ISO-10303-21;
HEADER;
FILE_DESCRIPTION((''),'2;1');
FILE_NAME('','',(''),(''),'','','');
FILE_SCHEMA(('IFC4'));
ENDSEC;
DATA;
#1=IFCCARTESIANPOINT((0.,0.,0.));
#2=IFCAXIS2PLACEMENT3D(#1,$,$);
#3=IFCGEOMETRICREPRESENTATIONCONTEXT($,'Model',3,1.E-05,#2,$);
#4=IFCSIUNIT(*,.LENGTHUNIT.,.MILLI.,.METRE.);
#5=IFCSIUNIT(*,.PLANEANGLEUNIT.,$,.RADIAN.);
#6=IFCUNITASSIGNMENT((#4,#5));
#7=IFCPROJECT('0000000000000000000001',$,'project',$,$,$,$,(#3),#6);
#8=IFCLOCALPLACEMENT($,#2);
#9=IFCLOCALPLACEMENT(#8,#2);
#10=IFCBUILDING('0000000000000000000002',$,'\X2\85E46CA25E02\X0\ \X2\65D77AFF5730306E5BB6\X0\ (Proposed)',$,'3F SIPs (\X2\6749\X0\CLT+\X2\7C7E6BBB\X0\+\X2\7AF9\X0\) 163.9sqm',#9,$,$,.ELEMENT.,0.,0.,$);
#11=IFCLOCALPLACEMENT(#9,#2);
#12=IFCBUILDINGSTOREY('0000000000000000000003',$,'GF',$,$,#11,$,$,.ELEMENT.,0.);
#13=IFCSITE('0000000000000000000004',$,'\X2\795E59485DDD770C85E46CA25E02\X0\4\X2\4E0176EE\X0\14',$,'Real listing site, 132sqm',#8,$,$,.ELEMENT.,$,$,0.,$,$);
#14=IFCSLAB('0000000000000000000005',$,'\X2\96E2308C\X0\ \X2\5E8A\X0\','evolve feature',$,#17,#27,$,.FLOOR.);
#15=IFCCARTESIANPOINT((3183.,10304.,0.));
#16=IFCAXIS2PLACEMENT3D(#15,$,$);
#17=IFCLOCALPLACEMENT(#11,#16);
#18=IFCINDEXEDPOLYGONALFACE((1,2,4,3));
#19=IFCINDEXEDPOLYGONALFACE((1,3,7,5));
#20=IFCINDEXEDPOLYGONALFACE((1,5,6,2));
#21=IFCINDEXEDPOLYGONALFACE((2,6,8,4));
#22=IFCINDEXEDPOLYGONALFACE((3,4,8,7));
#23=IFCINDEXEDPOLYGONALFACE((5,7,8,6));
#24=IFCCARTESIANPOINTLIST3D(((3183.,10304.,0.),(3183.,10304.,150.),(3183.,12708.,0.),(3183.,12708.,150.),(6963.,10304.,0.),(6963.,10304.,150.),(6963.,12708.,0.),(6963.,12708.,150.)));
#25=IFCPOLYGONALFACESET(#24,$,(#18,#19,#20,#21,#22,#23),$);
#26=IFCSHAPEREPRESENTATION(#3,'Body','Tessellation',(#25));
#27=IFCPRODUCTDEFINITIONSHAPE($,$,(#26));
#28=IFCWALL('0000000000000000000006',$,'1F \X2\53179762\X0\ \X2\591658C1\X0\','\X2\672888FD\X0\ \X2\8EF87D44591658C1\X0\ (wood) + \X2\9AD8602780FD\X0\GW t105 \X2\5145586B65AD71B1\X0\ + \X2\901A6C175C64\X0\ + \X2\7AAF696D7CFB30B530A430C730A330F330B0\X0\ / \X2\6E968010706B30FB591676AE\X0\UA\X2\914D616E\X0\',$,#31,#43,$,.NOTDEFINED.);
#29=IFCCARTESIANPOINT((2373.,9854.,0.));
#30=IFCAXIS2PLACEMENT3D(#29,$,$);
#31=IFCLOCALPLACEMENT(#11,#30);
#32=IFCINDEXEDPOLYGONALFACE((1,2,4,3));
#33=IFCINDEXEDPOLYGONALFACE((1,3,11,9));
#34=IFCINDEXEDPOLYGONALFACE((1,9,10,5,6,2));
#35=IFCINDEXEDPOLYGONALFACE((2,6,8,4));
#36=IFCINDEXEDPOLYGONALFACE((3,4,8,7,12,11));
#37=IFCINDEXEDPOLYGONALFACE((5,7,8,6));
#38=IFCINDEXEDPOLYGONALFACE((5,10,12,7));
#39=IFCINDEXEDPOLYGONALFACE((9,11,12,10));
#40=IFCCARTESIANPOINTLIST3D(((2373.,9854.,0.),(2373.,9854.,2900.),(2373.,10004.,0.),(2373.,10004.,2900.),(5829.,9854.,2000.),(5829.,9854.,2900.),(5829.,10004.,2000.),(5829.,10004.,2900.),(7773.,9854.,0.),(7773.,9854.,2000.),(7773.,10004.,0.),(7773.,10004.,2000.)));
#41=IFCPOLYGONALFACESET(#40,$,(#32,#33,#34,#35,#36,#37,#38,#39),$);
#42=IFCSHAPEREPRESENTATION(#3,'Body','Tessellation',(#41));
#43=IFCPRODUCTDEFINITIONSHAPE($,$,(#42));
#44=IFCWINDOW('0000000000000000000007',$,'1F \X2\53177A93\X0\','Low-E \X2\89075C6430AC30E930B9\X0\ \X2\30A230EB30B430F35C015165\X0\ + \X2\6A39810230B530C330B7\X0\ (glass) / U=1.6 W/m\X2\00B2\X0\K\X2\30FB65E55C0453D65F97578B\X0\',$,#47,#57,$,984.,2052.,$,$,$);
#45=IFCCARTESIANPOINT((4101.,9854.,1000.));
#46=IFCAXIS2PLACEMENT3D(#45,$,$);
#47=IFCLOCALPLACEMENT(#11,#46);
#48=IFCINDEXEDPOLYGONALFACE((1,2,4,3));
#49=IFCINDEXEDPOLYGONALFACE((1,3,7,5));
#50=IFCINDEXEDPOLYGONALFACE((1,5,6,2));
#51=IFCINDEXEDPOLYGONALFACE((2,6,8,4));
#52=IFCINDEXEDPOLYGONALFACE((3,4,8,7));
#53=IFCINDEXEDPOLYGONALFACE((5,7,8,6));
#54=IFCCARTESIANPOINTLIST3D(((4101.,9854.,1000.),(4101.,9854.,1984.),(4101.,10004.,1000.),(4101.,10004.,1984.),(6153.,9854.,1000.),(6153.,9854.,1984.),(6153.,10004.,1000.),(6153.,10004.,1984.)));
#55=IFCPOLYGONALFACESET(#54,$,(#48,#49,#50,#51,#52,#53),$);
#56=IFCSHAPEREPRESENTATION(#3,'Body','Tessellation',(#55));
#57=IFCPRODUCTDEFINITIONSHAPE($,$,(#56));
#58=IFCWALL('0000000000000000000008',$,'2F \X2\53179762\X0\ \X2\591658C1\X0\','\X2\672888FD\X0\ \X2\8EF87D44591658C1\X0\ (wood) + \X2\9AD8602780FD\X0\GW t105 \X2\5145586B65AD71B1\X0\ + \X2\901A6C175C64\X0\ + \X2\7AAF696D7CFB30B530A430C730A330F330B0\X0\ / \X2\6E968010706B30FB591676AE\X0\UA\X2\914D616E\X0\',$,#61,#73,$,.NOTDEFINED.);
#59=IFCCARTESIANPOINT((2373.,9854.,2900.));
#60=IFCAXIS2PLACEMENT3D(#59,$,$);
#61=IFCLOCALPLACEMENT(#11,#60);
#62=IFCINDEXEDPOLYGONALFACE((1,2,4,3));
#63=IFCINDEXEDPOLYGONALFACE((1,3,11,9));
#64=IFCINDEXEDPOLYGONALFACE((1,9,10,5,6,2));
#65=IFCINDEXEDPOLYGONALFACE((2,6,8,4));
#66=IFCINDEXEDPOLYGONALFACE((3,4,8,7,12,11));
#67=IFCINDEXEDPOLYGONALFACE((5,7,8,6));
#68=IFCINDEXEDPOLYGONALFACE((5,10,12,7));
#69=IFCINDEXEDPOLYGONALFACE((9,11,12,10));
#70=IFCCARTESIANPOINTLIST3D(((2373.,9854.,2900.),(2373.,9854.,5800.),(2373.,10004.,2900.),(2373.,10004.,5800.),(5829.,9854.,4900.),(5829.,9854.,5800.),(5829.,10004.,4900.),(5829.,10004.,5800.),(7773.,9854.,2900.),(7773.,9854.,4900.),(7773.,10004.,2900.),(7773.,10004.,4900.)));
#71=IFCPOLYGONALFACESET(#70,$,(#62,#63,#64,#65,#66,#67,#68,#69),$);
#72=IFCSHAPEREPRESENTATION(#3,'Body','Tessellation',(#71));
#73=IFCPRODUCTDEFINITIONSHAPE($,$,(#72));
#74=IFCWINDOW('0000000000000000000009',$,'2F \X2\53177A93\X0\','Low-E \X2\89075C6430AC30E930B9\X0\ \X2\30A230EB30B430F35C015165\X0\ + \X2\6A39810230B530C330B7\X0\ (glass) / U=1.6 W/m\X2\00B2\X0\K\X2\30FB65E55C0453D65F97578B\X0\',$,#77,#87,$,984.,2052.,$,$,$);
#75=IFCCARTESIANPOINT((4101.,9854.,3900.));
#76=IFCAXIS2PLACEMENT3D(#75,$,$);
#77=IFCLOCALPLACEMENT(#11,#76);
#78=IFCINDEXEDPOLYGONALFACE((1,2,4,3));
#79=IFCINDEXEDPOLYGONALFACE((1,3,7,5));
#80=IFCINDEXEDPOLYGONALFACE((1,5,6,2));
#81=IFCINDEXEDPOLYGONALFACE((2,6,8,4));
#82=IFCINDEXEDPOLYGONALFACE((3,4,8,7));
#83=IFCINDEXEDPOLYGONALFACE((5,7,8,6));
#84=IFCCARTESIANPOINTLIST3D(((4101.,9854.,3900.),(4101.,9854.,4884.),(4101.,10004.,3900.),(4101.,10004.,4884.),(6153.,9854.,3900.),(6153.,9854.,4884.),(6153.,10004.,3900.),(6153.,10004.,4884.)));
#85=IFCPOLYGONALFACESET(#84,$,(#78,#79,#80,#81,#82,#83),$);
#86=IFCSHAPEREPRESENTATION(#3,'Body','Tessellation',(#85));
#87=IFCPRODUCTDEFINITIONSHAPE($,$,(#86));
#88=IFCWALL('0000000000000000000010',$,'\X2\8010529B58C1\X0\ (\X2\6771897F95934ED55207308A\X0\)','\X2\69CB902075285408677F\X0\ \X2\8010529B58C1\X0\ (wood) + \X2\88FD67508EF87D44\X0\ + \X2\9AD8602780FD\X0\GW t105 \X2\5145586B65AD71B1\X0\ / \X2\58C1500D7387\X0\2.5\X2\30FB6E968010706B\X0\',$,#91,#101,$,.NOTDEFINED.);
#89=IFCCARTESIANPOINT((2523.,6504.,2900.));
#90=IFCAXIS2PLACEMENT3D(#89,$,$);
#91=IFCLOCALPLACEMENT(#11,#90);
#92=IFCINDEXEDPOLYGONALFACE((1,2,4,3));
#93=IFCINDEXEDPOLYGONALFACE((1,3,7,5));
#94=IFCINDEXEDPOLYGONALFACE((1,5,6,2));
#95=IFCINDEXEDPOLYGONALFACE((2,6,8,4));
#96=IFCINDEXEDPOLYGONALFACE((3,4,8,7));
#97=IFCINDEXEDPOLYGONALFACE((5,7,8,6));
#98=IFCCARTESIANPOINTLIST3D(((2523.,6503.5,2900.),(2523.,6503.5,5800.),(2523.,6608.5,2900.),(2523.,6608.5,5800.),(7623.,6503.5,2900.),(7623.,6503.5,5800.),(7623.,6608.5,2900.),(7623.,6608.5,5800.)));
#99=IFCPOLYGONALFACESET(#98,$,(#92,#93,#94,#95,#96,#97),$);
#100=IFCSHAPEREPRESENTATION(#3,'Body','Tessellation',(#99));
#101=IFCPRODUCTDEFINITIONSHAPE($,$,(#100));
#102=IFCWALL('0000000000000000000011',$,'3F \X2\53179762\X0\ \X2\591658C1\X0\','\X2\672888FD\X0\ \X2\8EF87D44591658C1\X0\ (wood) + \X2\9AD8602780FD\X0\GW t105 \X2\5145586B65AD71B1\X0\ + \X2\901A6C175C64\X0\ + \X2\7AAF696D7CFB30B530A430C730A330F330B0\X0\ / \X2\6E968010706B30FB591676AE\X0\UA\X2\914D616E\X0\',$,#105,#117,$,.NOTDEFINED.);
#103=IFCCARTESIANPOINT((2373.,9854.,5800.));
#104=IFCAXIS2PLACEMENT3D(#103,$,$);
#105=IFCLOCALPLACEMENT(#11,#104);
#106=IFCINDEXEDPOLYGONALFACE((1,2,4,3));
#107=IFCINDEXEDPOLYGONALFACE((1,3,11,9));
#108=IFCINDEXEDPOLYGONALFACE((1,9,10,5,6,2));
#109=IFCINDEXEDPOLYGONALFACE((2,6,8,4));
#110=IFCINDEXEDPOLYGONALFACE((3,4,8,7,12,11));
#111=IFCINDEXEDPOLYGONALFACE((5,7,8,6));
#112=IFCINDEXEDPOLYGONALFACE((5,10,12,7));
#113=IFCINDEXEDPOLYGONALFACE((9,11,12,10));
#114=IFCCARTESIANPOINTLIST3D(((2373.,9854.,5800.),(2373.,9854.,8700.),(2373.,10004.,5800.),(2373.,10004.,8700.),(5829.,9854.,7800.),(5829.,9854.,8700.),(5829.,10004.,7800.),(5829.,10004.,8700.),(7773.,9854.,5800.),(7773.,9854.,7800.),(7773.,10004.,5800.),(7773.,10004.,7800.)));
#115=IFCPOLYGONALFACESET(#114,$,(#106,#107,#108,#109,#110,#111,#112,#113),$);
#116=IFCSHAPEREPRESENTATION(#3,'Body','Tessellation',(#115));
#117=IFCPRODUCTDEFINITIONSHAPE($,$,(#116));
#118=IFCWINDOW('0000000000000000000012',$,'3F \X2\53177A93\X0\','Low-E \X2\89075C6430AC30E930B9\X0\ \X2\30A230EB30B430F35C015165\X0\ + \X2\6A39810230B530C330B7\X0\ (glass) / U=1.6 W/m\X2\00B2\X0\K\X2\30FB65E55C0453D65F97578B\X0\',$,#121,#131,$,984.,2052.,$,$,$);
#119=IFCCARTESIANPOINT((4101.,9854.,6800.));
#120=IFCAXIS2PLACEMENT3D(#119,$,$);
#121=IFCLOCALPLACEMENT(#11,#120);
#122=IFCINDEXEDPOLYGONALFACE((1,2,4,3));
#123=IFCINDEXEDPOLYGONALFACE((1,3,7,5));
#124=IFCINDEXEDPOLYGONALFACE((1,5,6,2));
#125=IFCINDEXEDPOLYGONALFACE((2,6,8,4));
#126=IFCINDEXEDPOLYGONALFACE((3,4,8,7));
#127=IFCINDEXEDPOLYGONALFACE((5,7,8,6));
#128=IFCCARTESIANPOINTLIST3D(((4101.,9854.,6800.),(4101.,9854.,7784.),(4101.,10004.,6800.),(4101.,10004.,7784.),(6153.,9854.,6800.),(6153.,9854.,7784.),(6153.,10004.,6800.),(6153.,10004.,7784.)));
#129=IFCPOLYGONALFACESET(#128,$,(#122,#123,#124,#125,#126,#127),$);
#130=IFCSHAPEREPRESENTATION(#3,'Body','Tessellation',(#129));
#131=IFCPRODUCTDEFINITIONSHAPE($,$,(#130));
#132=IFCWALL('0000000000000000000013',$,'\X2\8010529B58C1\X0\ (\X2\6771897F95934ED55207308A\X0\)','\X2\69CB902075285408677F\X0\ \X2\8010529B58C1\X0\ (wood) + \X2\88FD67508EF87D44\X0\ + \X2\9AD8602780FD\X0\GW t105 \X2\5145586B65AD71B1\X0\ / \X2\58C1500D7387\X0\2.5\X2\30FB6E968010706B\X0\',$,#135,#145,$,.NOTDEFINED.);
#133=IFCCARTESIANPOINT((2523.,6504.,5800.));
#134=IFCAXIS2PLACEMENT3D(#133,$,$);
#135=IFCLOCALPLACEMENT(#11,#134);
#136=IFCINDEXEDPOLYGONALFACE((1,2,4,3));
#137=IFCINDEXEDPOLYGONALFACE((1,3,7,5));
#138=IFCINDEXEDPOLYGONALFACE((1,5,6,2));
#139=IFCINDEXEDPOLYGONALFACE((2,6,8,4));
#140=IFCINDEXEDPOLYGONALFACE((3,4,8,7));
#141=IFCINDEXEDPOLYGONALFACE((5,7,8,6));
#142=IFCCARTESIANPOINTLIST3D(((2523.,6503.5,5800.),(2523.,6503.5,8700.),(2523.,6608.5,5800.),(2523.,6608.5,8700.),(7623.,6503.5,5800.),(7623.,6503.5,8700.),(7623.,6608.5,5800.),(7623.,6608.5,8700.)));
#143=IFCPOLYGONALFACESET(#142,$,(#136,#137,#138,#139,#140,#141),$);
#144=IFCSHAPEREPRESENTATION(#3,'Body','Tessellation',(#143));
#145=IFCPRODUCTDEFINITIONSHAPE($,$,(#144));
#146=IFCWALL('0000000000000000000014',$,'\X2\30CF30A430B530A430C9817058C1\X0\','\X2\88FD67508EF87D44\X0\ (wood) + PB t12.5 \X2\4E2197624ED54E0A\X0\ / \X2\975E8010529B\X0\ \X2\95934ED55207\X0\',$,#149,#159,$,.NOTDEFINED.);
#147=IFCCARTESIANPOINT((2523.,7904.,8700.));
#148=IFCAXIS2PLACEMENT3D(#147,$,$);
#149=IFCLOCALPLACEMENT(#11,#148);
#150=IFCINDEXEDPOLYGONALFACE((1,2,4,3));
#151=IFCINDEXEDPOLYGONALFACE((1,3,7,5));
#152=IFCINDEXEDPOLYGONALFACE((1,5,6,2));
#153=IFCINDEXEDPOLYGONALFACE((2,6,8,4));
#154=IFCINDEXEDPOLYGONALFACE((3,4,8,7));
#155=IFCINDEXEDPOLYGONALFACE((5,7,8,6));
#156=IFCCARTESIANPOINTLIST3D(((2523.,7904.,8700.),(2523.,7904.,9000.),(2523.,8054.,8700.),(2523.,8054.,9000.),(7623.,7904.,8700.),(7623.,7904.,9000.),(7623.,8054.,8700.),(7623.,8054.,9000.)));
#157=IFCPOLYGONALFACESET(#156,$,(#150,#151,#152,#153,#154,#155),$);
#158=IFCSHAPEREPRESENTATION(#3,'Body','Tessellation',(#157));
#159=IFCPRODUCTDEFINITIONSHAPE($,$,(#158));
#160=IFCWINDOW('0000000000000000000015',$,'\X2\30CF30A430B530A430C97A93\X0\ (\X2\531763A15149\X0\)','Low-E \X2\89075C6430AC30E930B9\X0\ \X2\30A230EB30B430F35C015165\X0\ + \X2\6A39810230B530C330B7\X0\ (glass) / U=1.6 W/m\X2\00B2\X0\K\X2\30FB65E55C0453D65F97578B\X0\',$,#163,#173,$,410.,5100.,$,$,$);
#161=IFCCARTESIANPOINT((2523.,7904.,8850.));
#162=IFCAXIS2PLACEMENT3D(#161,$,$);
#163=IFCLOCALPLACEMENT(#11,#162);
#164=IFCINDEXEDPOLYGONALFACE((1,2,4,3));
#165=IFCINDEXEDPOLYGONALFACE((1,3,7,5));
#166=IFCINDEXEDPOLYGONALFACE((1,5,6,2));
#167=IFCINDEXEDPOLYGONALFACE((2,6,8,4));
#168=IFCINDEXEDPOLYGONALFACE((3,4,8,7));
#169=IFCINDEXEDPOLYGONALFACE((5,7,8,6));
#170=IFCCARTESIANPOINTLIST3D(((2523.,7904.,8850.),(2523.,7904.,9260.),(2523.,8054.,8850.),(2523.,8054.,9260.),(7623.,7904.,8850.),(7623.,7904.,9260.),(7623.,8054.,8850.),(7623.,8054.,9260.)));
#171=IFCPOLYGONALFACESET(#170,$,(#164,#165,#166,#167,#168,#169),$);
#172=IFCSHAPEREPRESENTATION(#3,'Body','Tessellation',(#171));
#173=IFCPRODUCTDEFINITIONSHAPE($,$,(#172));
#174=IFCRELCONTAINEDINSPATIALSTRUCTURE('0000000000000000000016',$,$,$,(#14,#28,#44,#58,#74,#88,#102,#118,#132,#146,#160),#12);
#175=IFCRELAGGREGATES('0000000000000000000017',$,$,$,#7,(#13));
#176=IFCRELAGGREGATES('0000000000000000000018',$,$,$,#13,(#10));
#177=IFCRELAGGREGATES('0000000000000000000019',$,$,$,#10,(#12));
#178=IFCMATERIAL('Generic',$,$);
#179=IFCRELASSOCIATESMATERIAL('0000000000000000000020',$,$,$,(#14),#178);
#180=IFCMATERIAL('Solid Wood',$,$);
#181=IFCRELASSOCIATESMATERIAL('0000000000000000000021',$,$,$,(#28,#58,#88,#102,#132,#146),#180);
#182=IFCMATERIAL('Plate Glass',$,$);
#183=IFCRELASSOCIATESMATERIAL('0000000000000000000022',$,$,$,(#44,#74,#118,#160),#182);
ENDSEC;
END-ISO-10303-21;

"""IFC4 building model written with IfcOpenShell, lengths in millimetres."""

from ifc_helpers import new_model, si_unit, frame, frame_2d, origin, place, context, project, spatial, rectangle, extrude, material, element, fill, save


model = new_model("IFC4")

# Units and contexts
model_context = context("Model", 3, precision=1e-05, world=origin())
ifc_project = project(units=[si_unit("LENGTHUNIT", "METRE", prefix="MILLI"), si_unit("PLANEANGLEUNIT", "RADIAN")], contexts=[model_context])

# Site, building, storey
site_placement = place(None, origin())
site = spatial("IfcSite", under=ifc_project, at=site_placement, Name="神奈川県藤沢市4丁目14", ObjectType="Real listing site, 132sqm", CompositionType="ELEMENT", RefElevation=0.0)
building_placement = place(site_placement, origin())
building = spatial("IfcBuilding", under=site, at=building_placement, Name="藤沢市 旗竿地の家 (Proposed)", ObjectType="3F SIPs (杉CLT+籾殻+竹) 163.9sqm", CompositionType="ELEMENT", ElevationOfRefHeight=0.0, ElevationOfTerrain=0.0)
storey_placement = place(building_placement, origin())
storey = spatial("IfcBuildingStorey", under=building, at=storey_placement, Name="GF", CompositionType="ELEMENT", Elevation=0.0)

# Slab
ifc_material_1 = material(Name="Generic")
slab_placement = place(storey_placement, frame((3183.0, 10304.0, 0.0)))
element("IfcSlab", 1, at=slab_placement, inside=storey, material=ifc_material_1, Name="離れ 床", Description="evolve feature", PredefinedType="FLOOR", context=model_context, shape_type="SweptSolid", body=[
    extrude(rectangle(XDim=3780.0, YDim=2404.0, at=frame_2d((1890.0, 1202.0))), frame((3183.0, 10304.0, 0.0)), (0.0, 0.0, 1.0), 150.0),
])

# Wall, opening, window
ifc_material_2 = material(Name="Solid Wood")
wall_1_placement = place(storey_placement, frame((2373.0, 9854.0, 0.0)))
wall_1 = element("IfcWall", 2, at=wall_1_placement, inside=storey, material=ifc_material_2, Name="1F 北面 外壁", Description="木製 軸組外壁 (wood) + 高性能GW t105 充填断熱 + 通気層 + 窯業系サイディング / 準耐火・外皮UA配慮", PredefinedType="NOTDEFINED", context=model_context, shape_type="SweptSolid", body=[
    extrude(rectangle(XDim=5400.0, YDim=150.0, at=frame_2d((2700.0, 75.0))), frame((2373.0, 9854.0, 0.0)), (0.0, 0.0, 1.0), 2900.0),
])
opening_1_placement = place(storey_placement, frame((4101.0, 9854.0, 1000.0)))
opening_1 = element("IfcOpeningElement", 3, at=opening_1_placement, cuts=wall_1, PredefinedType="NOTDEFINED", context=model_context, shape_type="SweptSolid", body=[
    extrude(rectangle(XDim=2052.0, YDim=150.0, at=frame_2d((1026.0, 75.0))), frame((4101.0, 9854.0, 1000.0)), (0.0, 0.0, 1.0), 984.0),
])
ifc_material_3 = material(Name="Plate Glass")
window_1_placement = place(storey_placement, frame((4101.0, 9854.0, 1000.0)))
window_1 = element("IfcWindow", 4, at=window_1_placement, inside=storey, material=ifc_material_3, Name="1F 北窓", Description="Low-E 複層ガラス アルゴン封入 + 樹脂サッシ (glass) / U=1.6 W/m²K・日射取得型", OverallHeight=984.0, OverallWidth=2052.0, context=model_context, shape_type="SweptSolid", body=[
    extrude(rectangle(XDim=2052.0, YDim=150.0, at=frame_2d((1026.0, 75.0))), frame((4101.0, 9854.0, 1000.0)), (0.0, 0.0, 1.0), 984.0),
])
fill(opening_1, window_1)

# Wall, opening, window
wall_2_placement = place(storey_placement, frame((2373.0, 9854.0, 2900.0)))
wall_2 = element("IfcWall", 5, at=wall_2_placement, inside=storey, material=ifc_material_2, Name="2F 北面 外壁", Description="木製 軸組外壁 (wood) + 高性能GW t105 充填断熱 + 通気層 + 窯業系サイディング / 準耐火・外皮UA配慮", PredefinedType="NOTDEFINED", context=model_context, shape_type="SweptSolid", body=[
    extrude(rectangle(XDim=5400.0, YDim=150.0, at=frame_2d((2700.0, 75.0))), frame((2373.0, 9854.0, 2900.0)), (0.0, 0.0, 1.0), 2900.0),
])
opening_2_placement = place(storey_placement, frame((4101.0, 9854.0, 3900.0)))
opening_2 = element("IfcOpeningElement", 6, at=opening_2_placement, cuts=wall_2, PredefinedType="NOTDEFINED", context=model_context, shape_type="SweptSolid", body=[
    extrude(rectangle(XDim=2052.0, YDim=150.0, at=frame_2d((1026.0, 75.0))), frame((4101.0, 9854.0, 3900.0)), (0.0, 0.0, 1.0), 984.0),
])
window_2_placement = place(storey_placement, frame((4101.0, 9854.0, 3900.0)))
window_2 = element("IfcWindow", 7, at=window_2_placement, inside=storey, material=ifc_material_3, Name="2F 北窓", Description="Low-E 複層ガラス アルゴン封入 + 樹脂サッシ (glass) / U=1.6 W/m²K・日射取得型", OverallHeight=984.0, OverallWidth=2052.0, context=model_context, shape_type="SweptSolid", body=[
    extrude(rectangle(XDim=2052.0, YDim=150.0, at=frame_2d((1026.0, 75.0))), frame((4101.0, 9854.0, 3900.0)), (0.0, 0.0, 1.0), 984.0),
])
fill(opening_2, window_2)

# Wall
wall_3_placement = place(storey_placement, frame((2523.0, 6504.0, 2900.0)))
element("IfcWall", 8, at=wall_3_placement, inside=storey, material=ifc_material_2, Name="耐力壁 (東西間仕切り)", Description="構造用合板 耐力壁 (wood) + 製材軸組 + 高性能GW t105 充填断熱 / 壁倍率2.5・準耐火", PredefinedType="NOTDEFINED", context=model_context, shape_type="SweptSolid", body=[
    extrude(rectangle(XDim=5100.0, YDim=105.0, at=frame_2d((2550.0, 52.0))), frame((2523.0, 6504.0, 2900.0)), (0.0, 0.0, 1.0), 2900.0),
])

# Wall, opening, window
wall_4_placement = place(storey_placement, frame((2373.0, 9854.0, 5800.0)))
wall_4 = element("IfcWall", 9, at=wall_4_placement, inside=storey, material=ifc_material_2, Name="3F 北面 外壁", Description="木製 軸組外壁 (wood) + 高性能GW t105 充填断熱 + 通気層 + 窯業系サイディング / 準耐火・外皮UA配慮", PredefinedType="NOTDEFINED", context=model_context, shape_type="SweptSolid", body=[
    extrude(rectangle(XDim=5400.0, YDim=150.0, at=frame_2d((2700.0, 75.0))), frame((2373.0, 9854.0, 5800.0)), (0.0, 0.0, 1.0), 2900.0),
])
opening_3_placement = place(storey_placement, frame((4101.0, 9854.0, 6800.0)))
opening_3 = element("IfcOpeningElement", 10, at=opening_3_placement, cuts=wall_4, PredefinedType="NOTDEFINED", context=model_context, shape_type="SweptSolid", body=[
    extrude(rectangle(XDim=2052.0, YDim=150.0, at=frame_2d((1026.0, 75.0))), frame((4101.0, 9854.0, 6800.0)), (0.0, 0.0, 1.0), 984.0),
])
window_3_placement = place(storey_placement, frame((4101.0, 9854.0, 6800.0)))
window_3 = element("IfcWindow", 11, at=window_3_placement, inside=storey, material=ifc_material_3, Name="3F 北窓", Description="Low-E 複層ガラス アルゴン封入 + 樹脂サッシ (glass) / U=1.6 W/m²K・日射取得型", OverallHeight=984.0, OverallWidth=2052.0, context=model_context, shape_type="SweptSolid", body=[
    extrude(rectangle(XDim=2052.0, YDim=150.0, at=frame_2d((1026.0, 75.0))), frame((4101.0, 9854.0, 6800.0)), (0.0, 0.0, 1.0), 984.0),
])
fill(opening_3, window_3)

# Wall
wall_5_placement = place(storey_placement, frame((2523.0, 6504.0, 5800.0)))
element("IfcWall", 12, at=wall_5_placement, inside=storey, material=ifc_material_2, Name="耐力壁 (東西間仕切り)", Description="構造用合板 耐力壁 (wood) + 製材軸組 + 高性能GW t105 充填断熱 / 壁倍率2.5・準耐火", PredefinedType="NOTDEFINED", context=model_context, shape_type="SweptSolid", body=[
    extrude(rectangle(XDim=5100.0, YDim=105.0, at=frame_2d((2550.0, 52.0))), frame((2523.0, 6504.0, 5800.0)), (0.0, 0.0, 1.0), 2900.0),
])

# Wall, opening, window
wall_6_placement = place(storey_placement, frame((2523.0, 7904.0, 8700.0)))
wall_6 = element("IfcWall", 13, at=wall_6_placement, inside=storey, material=ifc_material_2, Name="ハイサイド腰壁", Description="製材軸組 (wood) + PB t12.5 両面仕上 / 非耐力 間仕切", PredefinedType="NOTDEFINED", context=model_context, shape_type="SweptSolid", body=[
    extrude(rectangle(XDim=5100.0, YDim=150.0, at=frame_2d((2550.0, 75.0))), frame((2523.0, 7904.0, 8700.0)), (0.0, 0.0, 1.0), 700.0),
])
opening_4_placement = place(storey_placement, frame((2523.0, 7904.0, 8850.0)))
opening_4 = element("IfcOpeningElement", 14, at=opening_4_placement, cuts=wall_6, PredefinedType="NOTDEFINED", context=model_context, shape_type="SweptSolid", body=[
    extrude(rectangle(XDim=5100.0, YDim=150.0, at=frame_2d((2550.0, 75.0))), frame((2523.0, 7904.0, 8850.0)), (0.0, 0.0, 1.0), 410.0),
])
window_4_placement = place(storey_placement, frame((2523.0, 7904.0, 8850.0)))
window_4 = element("IfcWindow", 15, at=window_4_placement, inside=storey, material=ifc_material_3, Name="ハイサイド窓 (北採光)", Description="Low-E 複層ガラス アルゴン封入 + 樹脂サッシ (glass) / U=1.6 W/m²K・日射取得型", OverallHeight=410.0, OverallWidth=5100.0, context=model_context, shape_type="SweptSolid", body=[
    extrude(rectangle(XDim=5100.0, YDim=150.0, at=frame_2d((2550.0, 75.0))), frame((2523.0, 7904.0, 8850.0)), (0.0, 0.0, 1.0), 410.0),
])
fill(opening_4, window_4)

save(model, "model.ifc")
